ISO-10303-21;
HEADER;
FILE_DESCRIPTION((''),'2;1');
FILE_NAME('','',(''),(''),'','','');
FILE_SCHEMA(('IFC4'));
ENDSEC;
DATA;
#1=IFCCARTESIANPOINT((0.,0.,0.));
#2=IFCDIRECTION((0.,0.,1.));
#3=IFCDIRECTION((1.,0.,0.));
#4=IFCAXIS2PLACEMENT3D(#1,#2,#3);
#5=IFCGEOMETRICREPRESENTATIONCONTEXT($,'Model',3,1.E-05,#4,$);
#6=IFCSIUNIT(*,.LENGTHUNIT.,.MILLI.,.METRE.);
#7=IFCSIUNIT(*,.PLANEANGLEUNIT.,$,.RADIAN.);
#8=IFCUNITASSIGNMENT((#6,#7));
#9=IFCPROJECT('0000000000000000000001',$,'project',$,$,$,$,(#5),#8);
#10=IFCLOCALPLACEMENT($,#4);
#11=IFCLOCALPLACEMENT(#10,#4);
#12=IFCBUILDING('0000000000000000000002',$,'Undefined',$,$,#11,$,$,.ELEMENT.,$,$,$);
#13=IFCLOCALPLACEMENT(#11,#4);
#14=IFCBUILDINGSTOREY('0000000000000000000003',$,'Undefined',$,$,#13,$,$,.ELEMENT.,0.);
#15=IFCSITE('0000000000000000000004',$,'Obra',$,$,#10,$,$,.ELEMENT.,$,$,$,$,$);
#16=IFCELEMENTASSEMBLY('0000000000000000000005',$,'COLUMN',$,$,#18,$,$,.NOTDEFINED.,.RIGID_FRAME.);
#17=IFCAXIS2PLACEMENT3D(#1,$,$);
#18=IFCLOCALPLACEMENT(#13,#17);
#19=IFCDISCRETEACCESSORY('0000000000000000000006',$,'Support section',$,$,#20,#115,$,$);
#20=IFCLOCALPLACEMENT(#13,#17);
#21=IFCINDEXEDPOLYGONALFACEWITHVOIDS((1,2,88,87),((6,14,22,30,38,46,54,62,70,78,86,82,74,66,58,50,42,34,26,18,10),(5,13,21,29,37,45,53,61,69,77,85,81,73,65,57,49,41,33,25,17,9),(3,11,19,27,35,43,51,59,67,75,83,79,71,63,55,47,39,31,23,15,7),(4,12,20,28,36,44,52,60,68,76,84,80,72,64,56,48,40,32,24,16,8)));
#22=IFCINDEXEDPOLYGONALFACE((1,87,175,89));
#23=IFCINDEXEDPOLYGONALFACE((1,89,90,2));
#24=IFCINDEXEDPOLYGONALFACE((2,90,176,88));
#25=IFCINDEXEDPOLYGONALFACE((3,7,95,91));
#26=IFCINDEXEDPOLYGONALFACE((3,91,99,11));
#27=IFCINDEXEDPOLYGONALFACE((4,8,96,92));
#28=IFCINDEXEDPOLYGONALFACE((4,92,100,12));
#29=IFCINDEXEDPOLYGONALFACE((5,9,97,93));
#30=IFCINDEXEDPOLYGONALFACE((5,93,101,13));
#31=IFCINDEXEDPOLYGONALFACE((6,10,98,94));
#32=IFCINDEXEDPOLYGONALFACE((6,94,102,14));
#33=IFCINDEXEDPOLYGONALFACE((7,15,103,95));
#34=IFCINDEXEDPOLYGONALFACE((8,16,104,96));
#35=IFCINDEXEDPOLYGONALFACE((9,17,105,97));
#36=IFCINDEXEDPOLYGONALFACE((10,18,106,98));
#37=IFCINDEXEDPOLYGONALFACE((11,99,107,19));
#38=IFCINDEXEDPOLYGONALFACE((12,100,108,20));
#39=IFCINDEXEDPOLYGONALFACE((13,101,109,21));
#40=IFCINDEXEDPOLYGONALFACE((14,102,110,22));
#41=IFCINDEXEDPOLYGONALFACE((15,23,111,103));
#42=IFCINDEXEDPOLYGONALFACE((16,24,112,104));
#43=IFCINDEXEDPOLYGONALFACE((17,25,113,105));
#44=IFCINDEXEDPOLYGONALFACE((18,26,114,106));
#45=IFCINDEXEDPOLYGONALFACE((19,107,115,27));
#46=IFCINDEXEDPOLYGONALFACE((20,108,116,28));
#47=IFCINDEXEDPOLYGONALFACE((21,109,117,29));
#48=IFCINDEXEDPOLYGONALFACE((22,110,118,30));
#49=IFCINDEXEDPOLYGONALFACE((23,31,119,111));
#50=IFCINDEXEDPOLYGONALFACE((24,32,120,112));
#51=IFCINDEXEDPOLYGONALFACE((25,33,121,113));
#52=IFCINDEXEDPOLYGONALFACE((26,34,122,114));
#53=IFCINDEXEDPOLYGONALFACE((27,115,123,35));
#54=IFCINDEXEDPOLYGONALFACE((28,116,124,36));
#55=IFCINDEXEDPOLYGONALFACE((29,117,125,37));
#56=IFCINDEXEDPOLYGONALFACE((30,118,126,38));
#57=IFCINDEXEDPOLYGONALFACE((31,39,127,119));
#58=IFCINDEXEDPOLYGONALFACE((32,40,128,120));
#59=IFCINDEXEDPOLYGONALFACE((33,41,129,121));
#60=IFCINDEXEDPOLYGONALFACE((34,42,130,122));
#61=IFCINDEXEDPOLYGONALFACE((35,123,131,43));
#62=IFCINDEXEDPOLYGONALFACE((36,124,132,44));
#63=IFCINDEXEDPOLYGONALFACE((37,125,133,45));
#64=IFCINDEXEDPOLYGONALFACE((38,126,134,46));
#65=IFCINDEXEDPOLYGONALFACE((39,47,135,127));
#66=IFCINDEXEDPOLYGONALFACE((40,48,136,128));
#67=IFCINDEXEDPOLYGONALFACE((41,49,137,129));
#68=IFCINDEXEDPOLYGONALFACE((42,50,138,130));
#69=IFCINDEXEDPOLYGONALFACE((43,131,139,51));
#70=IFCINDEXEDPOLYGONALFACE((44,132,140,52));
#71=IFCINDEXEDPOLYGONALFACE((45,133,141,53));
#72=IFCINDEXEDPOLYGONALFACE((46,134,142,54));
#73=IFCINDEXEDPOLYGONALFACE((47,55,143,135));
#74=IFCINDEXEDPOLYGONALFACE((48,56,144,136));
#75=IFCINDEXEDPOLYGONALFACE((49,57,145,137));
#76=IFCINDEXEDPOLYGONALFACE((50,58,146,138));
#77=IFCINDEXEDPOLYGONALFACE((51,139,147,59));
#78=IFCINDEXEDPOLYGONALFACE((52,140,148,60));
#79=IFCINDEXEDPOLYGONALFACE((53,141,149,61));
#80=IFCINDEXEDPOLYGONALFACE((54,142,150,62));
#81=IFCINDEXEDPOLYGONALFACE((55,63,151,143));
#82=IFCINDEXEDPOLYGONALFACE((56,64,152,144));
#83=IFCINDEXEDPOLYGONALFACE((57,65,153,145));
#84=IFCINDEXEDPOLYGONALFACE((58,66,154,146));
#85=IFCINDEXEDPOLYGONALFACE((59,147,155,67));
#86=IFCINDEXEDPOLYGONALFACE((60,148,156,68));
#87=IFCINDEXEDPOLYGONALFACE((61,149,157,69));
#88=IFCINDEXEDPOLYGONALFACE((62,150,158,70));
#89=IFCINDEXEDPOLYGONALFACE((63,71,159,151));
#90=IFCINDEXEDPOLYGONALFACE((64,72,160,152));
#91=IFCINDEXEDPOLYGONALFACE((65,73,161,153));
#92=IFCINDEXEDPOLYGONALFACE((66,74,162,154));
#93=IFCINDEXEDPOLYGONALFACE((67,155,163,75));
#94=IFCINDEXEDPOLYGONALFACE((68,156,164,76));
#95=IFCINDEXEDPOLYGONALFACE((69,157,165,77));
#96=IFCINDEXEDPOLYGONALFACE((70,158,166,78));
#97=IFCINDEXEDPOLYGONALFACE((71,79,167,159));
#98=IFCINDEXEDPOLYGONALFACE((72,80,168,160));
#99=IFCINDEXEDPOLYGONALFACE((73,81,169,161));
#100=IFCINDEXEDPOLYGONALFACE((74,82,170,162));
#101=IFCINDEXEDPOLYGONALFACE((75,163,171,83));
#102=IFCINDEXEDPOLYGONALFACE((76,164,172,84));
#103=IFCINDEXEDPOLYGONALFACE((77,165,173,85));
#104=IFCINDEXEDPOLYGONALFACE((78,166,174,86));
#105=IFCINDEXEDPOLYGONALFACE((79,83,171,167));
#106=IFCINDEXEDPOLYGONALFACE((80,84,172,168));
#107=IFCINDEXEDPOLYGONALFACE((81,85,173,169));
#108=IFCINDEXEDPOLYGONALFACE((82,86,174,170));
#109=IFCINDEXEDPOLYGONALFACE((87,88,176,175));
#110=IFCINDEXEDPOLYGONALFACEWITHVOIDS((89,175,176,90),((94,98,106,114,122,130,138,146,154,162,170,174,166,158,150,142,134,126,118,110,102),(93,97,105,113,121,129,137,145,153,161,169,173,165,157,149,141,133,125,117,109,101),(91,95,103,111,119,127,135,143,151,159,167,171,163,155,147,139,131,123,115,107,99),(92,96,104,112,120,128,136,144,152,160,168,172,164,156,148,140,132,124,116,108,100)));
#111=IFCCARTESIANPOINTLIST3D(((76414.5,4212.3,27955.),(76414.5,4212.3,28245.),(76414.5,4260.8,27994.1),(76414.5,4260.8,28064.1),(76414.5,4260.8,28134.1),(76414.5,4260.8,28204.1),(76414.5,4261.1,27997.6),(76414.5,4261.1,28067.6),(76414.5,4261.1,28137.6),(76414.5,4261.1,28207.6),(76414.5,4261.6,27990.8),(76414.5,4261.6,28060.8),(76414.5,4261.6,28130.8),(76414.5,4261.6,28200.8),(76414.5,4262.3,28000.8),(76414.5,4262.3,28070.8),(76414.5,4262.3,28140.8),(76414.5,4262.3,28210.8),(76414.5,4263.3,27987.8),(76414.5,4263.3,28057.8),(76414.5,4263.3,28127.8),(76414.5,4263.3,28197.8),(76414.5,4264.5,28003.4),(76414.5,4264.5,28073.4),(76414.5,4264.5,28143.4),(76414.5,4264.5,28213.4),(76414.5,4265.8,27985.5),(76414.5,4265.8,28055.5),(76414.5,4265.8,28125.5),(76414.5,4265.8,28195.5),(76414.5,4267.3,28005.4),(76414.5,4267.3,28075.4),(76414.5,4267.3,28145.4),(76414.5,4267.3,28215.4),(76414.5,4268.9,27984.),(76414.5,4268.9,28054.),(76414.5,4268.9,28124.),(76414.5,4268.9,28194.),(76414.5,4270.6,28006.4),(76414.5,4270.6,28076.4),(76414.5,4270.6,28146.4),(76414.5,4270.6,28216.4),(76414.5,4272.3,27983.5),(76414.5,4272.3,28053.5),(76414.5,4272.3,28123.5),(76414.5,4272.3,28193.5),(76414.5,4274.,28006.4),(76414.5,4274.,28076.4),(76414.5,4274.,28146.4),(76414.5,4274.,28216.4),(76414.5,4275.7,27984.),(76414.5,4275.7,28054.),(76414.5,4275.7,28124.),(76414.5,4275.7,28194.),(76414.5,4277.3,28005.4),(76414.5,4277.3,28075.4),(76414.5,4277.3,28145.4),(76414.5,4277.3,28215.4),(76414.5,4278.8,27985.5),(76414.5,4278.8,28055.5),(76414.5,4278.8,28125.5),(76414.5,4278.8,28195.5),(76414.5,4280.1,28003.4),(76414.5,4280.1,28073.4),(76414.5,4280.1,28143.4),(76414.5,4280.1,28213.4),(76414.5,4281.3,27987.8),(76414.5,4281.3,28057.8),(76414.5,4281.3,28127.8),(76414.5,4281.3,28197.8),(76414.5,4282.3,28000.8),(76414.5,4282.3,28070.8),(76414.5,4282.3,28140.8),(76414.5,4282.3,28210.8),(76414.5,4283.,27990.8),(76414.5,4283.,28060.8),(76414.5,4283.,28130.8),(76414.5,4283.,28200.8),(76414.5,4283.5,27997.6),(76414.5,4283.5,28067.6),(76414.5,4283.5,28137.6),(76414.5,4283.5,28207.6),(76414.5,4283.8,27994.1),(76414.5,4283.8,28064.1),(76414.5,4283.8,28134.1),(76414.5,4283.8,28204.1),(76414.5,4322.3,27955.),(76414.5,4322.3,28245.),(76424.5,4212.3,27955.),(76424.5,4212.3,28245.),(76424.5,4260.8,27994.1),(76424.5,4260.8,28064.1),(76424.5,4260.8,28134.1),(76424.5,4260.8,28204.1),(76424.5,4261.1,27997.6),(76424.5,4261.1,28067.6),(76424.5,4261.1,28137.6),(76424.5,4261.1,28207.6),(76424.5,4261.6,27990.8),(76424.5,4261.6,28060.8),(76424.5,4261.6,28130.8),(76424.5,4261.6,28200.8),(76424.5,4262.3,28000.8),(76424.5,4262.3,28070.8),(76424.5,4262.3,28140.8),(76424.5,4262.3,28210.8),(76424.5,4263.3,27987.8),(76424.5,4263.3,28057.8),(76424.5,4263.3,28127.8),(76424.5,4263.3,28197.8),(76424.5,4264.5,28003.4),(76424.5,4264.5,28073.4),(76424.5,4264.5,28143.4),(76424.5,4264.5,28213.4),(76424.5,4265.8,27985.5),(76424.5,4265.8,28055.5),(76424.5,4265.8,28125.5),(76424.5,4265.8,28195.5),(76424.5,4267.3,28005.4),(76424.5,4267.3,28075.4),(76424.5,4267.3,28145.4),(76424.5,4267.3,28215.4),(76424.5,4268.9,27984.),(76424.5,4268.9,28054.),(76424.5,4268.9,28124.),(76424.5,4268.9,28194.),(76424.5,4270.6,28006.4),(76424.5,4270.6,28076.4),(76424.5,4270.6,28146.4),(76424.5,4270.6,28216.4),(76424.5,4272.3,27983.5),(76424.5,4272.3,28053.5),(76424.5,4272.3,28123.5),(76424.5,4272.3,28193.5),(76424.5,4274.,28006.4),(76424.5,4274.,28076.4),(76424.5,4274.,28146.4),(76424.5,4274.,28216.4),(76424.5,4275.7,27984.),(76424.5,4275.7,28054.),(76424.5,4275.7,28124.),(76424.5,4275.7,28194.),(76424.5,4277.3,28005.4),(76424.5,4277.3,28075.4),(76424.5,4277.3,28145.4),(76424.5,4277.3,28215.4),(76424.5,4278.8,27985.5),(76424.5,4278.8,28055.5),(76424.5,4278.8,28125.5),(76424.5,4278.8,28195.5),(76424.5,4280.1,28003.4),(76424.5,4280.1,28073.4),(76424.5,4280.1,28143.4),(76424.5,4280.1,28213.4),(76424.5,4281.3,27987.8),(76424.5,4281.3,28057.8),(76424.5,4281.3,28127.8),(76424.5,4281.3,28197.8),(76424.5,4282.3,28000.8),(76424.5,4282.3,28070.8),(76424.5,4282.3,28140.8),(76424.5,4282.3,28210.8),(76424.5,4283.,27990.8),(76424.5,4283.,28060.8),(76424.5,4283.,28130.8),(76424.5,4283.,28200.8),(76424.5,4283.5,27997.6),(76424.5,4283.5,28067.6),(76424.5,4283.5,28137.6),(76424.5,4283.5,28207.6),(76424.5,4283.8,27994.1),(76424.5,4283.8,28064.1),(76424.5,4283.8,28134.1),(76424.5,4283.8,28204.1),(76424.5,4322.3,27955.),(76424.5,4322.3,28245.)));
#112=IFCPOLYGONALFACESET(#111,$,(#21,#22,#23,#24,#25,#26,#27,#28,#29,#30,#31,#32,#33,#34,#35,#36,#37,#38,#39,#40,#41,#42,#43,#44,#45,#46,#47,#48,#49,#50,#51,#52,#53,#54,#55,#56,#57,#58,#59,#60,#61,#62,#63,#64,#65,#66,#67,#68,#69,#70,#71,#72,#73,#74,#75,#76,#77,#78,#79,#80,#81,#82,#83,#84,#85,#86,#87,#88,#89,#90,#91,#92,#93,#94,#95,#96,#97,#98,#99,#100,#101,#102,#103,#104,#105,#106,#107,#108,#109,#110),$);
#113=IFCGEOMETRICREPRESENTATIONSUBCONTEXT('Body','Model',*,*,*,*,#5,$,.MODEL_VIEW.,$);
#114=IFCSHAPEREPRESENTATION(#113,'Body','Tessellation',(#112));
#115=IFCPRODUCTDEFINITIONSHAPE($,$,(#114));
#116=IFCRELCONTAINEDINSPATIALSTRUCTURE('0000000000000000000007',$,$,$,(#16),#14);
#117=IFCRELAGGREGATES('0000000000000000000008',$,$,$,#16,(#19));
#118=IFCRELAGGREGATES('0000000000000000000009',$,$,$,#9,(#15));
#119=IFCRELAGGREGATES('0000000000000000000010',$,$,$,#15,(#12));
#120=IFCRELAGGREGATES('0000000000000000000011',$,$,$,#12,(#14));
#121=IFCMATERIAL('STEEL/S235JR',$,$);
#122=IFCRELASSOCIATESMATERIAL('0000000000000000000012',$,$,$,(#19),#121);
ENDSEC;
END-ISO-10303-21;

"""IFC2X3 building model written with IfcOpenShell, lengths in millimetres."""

from ifc_helpers import new_model, si_unit, frame, origin_with_axes, origin_2d_with_axis, place, context, subcontext, project, spatial, rectangle, circle, extrude, source, transform, mapped, material, element, aggregate, save


model = new_model("IFC2X3")

# Units and contexts
model_context = context("Model", 3, precision=1e-05, world=origin_with_axes())
body_context = subcontext(model_context, "Body", "Model", "MODEL_VIEW")
ifc_project = project(units=[si_unit("LENGTHUNIT", "METRE", prefix="MILLI"), si_unit("PLANEANGLEUNIT", "RADIAN")], contexts=[model_context])

# Site, building, storey
site_placement = place(None, origin_with_axes())
site = spatial("IfcSite", under=ifc_project, at=site_placement, Name="Obra", CompositionType="ELEMENT")
building_placement = place(site_placement, origin_with_axes())
building = spatial("IfcBuilding", under=site, at=building_placement, Name="Undefined", CompositionType="ELEMENT")
storey_placement = place(building_placement, origin_with_axes())
storey = spatial("IfcBuildingStorey", under=building, at=storey_placement, Name="Undefined", CompositionType="ELEMENT", Elevation=0.0)

# Shared definitions
ifc_material_1 = material(Name="STEEL/S235JR")

# Element assembly
assembly_1_placement = place(storey_placement, origin_with_axes())
assembly_1 = element("IfcElementAssembly", 1, at=assembly_1_placement, inside=storey, Name="COLUMN", AssemblyPlace="NOTDEFINED", PredefinedType="RIGID_FRAME")
shared_shape_1 = source(origin_with_axes(), body_context, "Body", "SweptSolid", [
    extrude(circle(Radius=11.5, at=origin_2d_with_axis()), frame((0.0, -14.4, 0.0), z_axis=(0.0, 1.0, 0.0), x_axis=(1.0, 0.0, 0.0)), (0.0, 0.0, 1.0), 10.2),
])

# Discrete accessory, opening
discrete_accessory_1_placement = place(assembly_1_placement, frame((76419.5, 4267.3, 27955.0), z_axis=(0.0, 0.0, 1.0), x_axis=(0.0, -1.0, 0.0)))
discrete_accessory_1 = element("IfcDiscreteAccessory", 2, at=discrete_accessory_1_placement, material=ifc_material_1, Name="Support section", context=body_context, shape_type="SweptSolid", body=[
    extrude(rectangle(XDim=10.0, YDim=110.0, at=origin_2d_with_axis()), frame((0.0, 0.0, 290.0), z_axis=(0.0, 0.0, -1.0), x_axis=(0.0, 1.0, 0.0)), (0.0, 0.0, 1.0), 290.0),
])
opening_1_placement = place(assembly_1_placement, frame((76410.2, 4222.3, 28300.0), z_axis=(0.0, 1.0, 0.0), x_axis=(0.0, 0.0, -1.0)))
element("IfcOpeningElement", 3, at=opening_1_placement, cuts=discrete_accessory_1, ObjectType="Opening", context=body_context, shape_type="MappedRepresentation", body=[
    mapped(shared_shape_1, transform((95.0, 0.0, 50.0))),
    mapped(shared_shape_1, transform((165.0, 0.0, 50.0))),
    mapped(shared_shape_1, transform((235.0, 0.0, 50.0))),
    mapped(shared_shape_1, transform((305.0, 0.0, 50.0))),
])
aggregate(assembly_1, [discrete_accessory_1])

save(model, "model.ifc")
